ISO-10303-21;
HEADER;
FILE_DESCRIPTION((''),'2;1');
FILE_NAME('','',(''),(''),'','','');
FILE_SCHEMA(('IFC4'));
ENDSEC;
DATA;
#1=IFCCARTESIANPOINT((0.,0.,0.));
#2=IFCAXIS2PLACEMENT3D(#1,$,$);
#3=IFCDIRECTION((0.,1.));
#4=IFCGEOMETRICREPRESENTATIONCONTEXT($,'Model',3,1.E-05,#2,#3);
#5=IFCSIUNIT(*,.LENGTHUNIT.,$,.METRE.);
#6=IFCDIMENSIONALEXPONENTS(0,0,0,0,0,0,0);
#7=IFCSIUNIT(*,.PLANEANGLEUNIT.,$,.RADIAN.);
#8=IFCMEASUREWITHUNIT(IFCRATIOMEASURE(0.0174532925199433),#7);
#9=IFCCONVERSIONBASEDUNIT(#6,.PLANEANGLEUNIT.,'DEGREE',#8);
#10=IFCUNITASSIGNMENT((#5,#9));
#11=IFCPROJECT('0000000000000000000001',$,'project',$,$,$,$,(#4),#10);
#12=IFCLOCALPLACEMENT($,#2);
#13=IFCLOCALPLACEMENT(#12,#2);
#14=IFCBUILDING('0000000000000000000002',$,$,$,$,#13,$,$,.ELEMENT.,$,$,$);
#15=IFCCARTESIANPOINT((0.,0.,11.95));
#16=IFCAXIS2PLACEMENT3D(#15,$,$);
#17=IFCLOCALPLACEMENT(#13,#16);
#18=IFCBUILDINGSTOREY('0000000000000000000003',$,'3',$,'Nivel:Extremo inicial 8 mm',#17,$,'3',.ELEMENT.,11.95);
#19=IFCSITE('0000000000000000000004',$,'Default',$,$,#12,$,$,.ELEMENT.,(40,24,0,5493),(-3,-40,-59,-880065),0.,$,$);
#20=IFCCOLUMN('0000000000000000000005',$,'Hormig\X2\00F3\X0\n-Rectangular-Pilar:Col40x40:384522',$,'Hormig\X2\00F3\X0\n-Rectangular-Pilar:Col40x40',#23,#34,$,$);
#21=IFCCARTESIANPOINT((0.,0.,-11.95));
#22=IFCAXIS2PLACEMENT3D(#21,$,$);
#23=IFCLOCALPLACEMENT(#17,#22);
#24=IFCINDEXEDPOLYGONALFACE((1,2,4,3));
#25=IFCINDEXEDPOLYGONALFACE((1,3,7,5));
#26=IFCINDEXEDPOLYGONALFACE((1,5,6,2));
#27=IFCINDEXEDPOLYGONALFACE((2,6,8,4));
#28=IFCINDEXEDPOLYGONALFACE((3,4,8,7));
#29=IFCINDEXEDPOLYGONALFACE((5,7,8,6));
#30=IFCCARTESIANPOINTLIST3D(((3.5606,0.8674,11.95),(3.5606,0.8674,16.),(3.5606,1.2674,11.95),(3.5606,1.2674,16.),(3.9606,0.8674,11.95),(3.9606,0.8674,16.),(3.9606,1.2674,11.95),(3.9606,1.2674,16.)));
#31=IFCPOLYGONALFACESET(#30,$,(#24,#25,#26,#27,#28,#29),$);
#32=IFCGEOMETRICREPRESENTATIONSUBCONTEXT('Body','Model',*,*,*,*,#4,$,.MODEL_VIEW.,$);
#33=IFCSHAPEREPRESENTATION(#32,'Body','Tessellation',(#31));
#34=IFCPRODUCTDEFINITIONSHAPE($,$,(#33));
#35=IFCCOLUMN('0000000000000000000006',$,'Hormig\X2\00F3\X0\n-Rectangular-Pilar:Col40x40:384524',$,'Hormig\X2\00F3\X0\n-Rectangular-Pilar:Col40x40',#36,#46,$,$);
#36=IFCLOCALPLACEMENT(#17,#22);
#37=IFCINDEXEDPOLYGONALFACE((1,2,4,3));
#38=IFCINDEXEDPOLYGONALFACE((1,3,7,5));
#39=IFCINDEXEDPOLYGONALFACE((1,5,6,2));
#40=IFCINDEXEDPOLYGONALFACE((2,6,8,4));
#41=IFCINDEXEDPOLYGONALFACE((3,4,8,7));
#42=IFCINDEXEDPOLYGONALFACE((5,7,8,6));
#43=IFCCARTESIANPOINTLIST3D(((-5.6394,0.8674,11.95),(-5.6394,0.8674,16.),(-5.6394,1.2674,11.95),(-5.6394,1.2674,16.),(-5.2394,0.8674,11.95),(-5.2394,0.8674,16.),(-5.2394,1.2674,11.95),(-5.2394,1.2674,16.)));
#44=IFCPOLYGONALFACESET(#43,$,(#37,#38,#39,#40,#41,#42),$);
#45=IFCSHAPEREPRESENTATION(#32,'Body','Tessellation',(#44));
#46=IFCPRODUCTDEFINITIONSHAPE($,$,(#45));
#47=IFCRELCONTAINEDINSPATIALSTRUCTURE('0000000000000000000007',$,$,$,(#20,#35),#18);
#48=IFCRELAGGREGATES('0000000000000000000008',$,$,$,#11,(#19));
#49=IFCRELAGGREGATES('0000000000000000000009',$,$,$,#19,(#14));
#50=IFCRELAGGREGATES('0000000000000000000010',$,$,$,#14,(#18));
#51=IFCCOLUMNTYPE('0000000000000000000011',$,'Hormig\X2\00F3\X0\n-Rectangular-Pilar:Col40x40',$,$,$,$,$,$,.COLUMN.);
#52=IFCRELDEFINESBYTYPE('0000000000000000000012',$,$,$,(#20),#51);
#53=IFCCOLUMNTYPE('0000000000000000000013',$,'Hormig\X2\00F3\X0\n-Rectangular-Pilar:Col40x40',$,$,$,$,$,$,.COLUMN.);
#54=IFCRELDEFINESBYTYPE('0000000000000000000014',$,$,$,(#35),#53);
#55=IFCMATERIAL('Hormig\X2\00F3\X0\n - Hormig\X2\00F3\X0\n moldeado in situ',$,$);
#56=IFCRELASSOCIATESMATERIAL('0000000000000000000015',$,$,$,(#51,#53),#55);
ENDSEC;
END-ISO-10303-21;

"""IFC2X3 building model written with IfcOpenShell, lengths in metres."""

from ifc_helpers import new_model, entity, si_unit, converted_unit, direction, frame, origin, origin_2d_with_axis, place, context, subcontext, project, spatial, rectangle, extrude, source, transform, mapped, material, type_object, type_shapes, element, save


model = new_model("IFC2X3")

# Units and contexts
model_context = context("Model", 3, precision=1e-05, world=origin(), true_north=direction((0.0, 1.0)))
body_context = subcontext(model_context, "Body", "Model", "MODEL_VIEW")
ifc_project = project(units=[si_unit("LENGTHUNIT", "METRE"), converted_unit("PLANEANGLEUNIT", "DEGREE", entity("IfcRatioMeasure", 0.0174532925199433), si_unit("PLANEANGLEUNIT", "RADIAN"), dimensions=[0, 0, 0, 0, 0, 0, 0])], contexts=[model_context])

# Site, building, storey
site_placement = place(None, origin())
site = spatial("IfcSite", under=ifc_project, at=site_placement, Name="Default", CompositionType="ELEMENT", RefLatitude=(40, 24, 0, 5493), RefLongitude=(-3, -40, -59, -880065), RefElevation=0.0)
building_placement = place(site_placement, origin())
building = spatial("IfcBuilding", under=site, at=building_placement, CompositionType="ELEMENT")
storey_placement = place(building_placement, frame((0.0, 0.0, 11.95)))
storey = spatial("IfcBuildingStorey", under=building, at=storey_placement, Name="3", ObjectType="Nivel:Extremo inicial 8 mm", LongName="3", CompositionType="ELEMENT", Elevation=11.95)

# Columns
ifc_material_1 = material(Name="Hormigón - Hormigón moldeado in situ")
column_type_1 = type_object("IfcColumnType", Name="Hormigón-Rectangular-Pilar:Col40x40", PredefinedType="COLUMN", material=ifc_material_1)
shared_shape_1 = source(origin(), body_context, "Body", "SweptSolid", [
    extrude(rectangle(XDim=0.4, YDim=0.4, at=origin_2d_with_axis()), frame((3.7606, 1.0674, 11.95), z_axis=(0.0, 0.0, 1.0), x_axis=(0.0, -1.0, 0.0)), (0.0, 0.0, 1.0), 4.05),
])
type_shapes(column_type_1, [shared_shape_1])
column_1_placement = place(storey_placement, frame((0.0, 0.0, -11.95)))
element("IfcColumn", 1, at=column_1_placement, inside=storey, type_object=column_type_1, Name="Hormigón-Rectangular-Pilar:Col40x40:384522", ObjectType="Hormigón-Rectangular-Pilar:Col40x40", context=body_context, shape_type="MappedRepresentation", body=[
    mapped(shared_shape_1, transform((0.0, 0.0, 0.0), scale=1.0)),
])
column_type_2 = type_object("IfcColumnType", Name="Hormigón-Rectangular-Pilar:Col40x40", PredefinedType="COLUMN", material=ifc_material_1)
shared_shape_2 = source(origin(), body_context, "Body", "SweptSolid", [
    extrude(rectangle(XDim=0.4, YDim=0.4, at=origin_2d_with_axis()), frame((-5.4394, 1.0674, 11.95), z_axis=(0.0, 0.0, 1.0), x_axis=(0.0, -1.0, 0.0)), (0.0, 0.0, 1.0), 4.05),
])
type_shapes(column_type_2, [shared_shape_2])
column_2_placement = place(storey_placement, frame((0.0, 0.0, -11.95)))
element("IfcColumn", 2, at=column_2_placement, inside=storey, type_object=column_type_2, Name="Hormigón-Rectangular-Pilar:Col40x40:384524", ObjectType="Hormigón-Rectangular-Pilar:Col40x40", context=body_context, shape_type="MappedRepresentation", body=[
    mapped(shared_shape_2, transform((0.0, 0.0, 0.0), scale=1.0)),
])

save(model, "model.ifc")
